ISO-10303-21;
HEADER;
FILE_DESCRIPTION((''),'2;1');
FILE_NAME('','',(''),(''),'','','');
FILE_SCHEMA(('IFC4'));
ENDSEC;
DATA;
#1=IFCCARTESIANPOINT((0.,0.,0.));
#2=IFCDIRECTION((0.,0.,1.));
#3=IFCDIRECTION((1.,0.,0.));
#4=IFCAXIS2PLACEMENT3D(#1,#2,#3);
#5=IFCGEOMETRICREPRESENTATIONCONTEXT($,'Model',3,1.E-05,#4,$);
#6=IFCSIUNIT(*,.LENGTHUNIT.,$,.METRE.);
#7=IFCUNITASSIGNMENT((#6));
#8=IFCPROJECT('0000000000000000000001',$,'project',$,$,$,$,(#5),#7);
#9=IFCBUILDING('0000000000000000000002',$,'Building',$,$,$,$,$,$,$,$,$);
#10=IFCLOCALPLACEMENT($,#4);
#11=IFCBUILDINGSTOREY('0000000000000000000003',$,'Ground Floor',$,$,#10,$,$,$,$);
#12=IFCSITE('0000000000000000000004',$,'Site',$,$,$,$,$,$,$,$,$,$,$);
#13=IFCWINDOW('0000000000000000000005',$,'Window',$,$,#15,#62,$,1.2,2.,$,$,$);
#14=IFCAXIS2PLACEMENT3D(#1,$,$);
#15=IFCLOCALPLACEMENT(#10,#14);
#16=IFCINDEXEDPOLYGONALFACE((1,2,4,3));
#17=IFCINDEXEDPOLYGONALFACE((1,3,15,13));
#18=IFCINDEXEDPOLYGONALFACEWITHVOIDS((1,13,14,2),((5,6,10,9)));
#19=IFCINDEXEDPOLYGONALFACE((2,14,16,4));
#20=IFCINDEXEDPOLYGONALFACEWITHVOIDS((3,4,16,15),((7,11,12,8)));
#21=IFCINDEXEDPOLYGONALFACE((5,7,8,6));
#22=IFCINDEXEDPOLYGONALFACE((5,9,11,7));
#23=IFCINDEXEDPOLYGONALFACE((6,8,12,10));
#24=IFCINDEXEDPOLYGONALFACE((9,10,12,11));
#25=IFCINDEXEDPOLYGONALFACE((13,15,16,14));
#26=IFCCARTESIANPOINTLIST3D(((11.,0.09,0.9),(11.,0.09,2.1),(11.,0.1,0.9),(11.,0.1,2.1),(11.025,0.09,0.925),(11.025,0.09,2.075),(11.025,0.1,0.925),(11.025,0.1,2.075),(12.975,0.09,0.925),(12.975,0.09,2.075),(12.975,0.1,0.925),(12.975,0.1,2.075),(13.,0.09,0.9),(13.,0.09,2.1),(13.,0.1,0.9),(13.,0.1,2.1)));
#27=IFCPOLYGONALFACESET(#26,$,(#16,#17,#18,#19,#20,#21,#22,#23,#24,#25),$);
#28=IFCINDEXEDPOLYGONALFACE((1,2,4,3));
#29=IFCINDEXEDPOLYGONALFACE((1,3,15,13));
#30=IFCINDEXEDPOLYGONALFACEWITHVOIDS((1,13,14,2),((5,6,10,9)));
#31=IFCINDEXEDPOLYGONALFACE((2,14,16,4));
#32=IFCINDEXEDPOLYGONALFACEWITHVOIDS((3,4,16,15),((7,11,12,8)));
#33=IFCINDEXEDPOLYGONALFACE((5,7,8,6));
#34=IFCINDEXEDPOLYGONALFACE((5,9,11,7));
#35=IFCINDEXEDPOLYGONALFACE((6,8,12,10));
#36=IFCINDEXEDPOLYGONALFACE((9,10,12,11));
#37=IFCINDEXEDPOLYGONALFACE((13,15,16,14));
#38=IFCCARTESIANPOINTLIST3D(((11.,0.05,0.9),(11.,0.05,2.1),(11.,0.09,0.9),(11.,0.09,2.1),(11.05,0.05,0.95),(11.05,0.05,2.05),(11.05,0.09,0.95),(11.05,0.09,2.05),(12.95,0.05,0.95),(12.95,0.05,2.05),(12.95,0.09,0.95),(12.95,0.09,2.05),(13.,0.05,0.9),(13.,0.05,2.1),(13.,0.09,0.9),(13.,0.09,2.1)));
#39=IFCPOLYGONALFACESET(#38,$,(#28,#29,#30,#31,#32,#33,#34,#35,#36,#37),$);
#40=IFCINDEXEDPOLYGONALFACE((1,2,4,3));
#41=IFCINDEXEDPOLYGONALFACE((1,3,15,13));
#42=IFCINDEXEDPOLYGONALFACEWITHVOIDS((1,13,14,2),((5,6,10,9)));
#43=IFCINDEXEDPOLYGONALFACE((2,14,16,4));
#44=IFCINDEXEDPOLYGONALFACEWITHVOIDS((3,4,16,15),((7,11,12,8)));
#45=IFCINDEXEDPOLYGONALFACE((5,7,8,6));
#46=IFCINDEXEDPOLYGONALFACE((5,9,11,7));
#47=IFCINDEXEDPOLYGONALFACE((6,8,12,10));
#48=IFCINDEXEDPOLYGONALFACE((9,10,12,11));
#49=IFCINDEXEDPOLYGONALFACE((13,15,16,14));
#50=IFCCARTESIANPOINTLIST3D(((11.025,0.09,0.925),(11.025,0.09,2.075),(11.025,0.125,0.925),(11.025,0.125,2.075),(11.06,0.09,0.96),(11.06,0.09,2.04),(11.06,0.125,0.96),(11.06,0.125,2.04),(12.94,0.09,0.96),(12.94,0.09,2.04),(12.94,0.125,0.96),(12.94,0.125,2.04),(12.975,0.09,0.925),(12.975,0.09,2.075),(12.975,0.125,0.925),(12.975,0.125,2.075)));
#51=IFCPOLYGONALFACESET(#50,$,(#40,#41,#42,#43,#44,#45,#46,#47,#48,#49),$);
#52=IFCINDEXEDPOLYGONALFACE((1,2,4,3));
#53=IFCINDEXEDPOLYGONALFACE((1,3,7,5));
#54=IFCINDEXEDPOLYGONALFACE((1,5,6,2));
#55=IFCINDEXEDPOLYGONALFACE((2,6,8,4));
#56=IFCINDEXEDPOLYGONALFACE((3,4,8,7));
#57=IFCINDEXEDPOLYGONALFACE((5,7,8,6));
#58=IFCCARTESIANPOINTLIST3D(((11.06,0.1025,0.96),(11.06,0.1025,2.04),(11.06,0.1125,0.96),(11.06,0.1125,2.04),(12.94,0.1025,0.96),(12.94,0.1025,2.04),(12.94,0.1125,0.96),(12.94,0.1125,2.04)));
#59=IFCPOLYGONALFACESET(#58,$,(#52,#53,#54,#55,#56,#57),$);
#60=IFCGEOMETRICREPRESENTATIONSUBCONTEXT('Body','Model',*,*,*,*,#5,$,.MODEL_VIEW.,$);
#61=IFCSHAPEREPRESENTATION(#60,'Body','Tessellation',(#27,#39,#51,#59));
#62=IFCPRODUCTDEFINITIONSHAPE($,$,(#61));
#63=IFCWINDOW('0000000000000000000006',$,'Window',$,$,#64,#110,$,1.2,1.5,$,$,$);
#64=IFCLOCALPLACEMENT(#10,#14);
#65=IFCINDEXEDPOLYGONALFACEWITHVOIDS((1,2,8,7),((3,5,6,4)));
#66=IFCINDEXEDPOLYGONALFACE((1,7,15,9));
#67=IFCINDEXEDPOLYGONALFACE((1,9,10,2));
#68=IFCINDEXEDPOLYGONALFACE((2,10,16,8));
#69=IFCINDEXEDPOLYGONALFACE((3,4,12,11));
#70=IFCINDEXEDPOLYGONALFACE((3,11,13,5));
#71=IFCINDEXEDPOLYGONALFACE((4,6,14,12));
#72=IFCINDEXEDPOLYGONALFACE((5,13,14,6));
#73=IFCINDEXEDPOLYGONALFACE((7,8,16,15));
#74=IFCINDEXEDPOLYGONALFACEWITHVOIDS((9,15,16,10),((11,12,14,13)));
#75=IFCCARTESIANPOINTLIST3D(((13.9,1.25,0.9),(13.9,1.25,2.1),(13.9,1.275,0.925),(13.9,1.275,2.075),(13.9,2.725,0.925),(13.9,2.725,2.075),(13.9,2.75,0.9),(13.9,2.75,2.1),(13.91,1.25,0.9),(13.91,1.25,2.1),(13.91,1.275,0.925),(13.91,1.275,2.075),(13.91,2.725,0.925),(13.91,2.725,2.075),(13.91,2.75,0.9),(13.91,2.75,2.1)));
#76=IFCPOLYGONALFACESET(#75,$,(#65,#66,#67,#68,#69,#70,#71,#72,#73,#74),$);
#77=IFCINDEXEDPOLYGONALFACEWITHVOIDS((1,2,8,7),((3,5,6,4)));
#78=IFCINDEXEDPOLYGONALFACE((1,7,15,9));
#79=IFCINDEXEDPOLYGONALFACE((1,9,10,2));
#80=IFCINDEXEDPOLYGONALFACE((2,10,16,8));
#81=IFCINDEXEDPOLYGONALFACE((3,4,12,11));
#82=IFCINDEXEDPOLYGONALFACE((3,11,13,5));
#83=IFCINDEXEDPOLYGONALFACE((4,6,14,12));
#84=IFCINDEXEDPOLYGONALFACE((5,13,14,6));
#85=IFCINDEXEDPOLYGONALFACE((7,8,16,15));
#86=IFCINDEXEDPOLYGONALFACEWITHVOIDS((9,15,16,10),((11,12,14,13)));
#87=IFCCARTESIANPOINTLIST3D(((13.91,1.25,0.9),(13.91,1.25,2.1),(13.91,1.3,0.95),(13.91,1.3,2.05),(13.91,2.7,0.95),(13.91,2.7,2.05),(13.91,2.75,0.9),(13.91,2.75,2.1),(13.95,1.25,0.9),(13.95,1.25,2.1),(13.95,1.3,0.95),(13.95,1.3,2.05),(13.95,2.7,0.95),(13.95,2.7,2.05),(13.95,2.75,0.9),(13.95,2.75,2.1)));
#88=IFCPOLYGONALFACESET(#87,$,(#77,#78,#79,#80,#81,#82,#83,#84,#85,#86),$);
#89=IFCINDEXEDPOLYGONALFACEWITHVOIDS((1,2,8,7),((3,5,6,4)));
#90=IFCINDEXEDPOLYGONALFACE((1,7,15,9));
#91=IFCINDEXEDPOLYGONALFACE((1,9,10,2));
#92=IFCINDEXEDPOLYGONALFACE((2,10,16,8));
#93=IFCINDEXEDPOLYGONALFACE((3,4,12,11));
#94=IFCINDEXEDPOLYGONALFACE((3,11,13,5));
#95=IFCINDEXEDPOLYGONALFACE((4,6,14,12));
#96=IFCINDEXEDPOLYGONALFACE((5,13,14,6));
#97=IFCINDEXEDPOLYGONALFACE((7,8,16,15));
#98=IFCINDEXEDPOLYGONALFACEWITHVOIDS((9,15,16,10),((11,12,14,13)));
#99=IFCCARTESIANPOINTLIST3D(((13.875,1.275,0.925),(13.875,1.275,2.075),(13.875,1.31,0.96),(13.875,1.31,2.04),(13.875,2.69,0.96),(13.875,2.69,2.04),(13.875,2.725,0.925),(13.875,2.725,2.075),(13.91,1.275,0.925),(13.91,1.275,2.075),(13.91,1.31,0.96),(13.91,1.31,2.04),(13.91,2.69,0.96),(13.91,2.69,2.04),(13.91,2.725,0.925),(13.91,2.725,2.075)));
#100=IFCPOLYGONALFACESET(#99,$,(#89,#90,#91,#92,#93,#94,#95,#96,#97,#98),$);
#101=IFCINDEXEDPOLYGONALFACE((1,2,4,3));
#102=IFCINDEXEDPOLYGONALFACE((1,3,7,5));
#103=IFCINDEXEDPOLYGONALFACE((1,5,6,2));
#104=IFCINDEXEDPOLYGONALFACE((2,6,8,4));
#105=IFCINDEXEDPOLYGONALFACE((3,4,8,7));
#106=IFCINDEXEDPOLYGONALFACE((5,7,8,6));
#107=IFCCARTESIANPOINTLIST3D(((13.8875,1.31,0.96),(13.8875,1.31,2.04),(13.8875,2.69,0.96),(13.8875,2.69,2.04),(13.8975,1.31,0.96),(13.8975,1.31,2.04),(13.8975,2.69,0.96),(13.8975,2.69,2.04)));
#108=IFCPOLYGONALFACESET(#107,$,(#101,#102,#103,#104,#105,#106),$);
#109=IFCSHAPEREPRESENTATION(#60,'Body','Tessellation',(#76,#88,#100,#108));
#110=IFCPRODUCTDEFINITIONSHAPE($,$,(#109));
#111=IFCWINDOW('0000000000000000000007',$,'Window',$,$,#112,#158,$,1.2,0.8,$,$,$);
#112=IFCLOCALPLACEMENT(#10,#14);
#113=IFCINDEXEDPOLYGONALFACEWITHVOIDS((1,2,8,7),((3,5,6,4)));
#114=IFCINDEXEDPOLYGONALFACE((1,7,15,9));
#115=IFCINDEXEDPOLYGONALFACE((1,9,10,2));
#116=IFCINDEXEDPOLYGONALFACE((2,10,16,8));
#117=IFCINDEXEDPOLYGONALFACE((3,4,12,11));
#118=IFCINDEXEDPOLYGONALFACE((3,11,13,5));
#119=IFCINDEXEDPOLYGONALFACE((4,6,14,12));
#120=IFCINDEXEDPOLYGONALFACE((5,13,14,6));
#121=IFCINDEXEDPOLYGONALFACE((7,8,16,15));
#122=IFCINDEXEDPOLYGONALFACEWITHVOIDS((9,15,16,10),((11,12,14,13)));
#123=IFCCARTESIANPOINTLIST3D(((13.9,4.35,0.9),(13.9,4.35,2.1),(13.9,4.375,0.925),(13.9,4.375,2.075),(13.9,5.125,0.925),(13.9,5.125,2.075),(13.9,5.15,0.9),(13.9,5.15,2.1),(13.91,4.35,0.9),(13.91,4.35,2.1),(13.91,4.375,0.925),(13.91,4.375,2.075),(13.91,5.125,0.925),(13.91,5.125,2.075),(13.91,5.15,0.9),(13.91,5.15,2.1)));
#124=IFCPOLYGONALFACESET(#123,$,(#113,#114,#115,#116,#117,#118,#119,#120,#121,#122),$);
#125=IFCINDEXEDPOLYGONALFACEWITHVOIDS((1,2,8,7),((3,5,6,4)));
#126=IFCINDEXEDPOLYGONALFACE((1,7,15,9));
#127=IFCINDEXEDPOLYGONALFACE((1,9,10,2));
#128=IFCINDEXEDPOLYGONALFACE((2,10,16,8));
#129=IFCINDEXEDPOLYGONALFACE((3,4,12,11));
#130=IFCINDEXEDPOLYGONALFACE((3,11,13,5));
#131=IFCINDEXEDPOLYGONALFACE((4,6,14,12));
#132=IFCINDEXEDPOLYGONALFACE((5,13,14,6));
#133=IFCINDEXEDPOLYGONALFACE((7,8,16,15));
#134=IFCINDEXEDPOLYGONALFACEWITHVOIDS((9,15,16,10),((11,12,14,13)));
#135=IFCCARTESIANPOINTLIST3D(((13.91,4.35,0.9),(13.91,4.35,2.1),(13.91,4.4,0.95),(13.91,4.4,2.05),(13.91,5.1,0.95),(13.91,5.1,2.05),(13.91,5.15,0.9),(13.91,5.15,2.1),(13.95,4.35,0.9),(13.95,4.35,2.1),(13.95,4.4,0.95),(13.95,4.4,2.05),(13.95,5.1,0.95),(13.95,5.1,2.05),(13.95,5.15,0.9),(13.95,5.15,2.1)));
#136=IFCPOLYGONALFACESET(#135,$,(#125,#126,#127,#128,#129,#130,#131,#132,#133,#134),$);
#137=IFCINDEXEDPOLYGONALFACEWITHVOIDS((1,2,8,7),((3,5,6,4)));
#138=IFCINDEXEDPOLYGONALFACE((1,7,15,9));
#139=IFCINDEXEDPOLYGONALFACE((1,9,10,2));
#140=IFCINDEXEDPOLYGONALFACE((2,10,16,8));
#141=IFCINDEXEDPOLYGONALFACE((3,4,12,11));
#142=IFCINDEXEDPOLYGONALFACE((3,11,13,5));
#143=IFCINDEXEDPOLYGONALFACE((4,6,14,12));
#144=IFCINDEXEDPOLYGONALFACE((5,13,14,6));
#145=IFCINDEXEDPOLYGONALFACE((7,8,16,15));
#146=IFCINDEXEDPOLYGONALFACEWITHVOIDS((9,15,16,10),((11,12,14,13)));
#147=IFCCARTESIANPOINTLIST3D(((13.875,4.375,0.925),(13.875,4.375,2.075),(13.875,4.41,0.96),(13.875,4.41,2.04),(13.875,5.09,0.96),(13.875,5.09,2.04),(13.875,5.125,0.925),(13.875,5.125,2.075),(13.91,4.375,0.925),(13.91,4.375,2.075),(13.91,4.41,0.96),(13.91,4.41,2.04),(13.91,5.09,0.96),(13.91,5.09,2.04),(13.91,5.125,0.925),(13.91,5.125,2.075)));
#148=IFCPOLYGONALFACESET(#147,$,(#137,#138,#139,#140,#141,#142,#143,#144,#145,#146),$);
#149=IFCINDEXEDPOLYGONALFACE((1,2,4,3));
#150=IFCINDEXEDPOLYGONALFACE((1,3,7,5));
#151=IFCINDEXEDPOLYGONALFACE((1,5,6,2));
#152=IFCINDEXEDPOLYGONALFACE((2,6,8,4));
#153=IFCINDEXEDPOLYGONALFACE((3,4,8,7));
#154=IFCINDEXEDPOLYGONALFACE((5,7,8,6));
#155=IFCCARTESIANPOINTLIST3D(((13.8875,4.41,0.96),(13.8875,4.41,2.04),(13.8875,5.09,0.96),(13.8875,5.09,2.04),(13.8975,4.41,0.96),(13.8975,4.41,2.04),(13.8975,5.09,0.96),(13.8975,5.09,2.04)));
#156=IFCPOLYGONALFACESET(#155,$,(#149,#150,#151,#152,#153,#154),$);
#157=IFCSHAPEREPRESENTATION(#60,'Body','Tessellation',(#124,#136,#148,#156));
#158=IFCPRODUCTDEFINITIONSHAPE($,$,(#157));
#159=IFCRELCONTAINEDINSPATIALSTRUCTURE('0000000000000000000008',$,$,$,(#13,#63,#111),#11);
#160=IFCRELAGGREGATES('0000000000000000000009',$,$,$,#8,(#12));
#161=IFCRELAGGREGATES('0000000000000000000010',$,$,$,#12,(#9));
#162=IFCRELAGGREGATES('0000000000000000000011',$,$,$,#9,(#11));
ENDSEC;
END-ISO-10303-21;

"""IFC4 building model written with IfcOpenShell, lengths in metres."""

from ifc_helpers import new_model, si_unit, frame, origin_with_axes, place, context, subcontext, project, spatial, line, indexed_curve, outline, extrude, element, save


model = new_model("IFC4")

# Units and contexts
model_context = context("Model", 3, precision=1e-05, world=origin_with_axes())
body_context = subcontext(model_context, "Body", "Model", "MODEL_VIEW")
ifc_project = project(units=[si_unit("LENGTHUNIT", "METRE")], contexts=[model_context])

# Site, building, storey
site = spatial("IfcSite", under=ifc_project, Name="Site")
building = spatial("IfcBuilding", under=site, Name="Building")
storey_placement = place(None, origin_with_axes())
storey = spatial("IfcBuildingStorey", under=building, at=storey_placement, Name="Ground Floor")

# Windows
window_1_placement = place(storey_placement, frame((11.0, 0.0, 0.9), z_axis=(0.0, 0.0, 1.0), x_axis=(1.0, 0.0, 0.0)))
element("IfcWindow", 1, at=window_1_placement, inside=storey, Name="Window", OverallHeight=1.2, OverallWidth=2.0, context=body_context, shape_type="SweptSolid", body=[
    extrude(outline(indexed_curve([(0.0, 0.0), (2.0, 0.0), (2.0, 1.2), (0.0, 1.2)], segments=[line(1, 2, 3, 4, 1)]), holes=[indexed_curve([(0.025, 0.025), (1.975, 0.025), (1.975, 1.175), (0.025, 1.175)], segments=[line(1, 2, 3, 4, 1)])]), frame((0.0, 0.09, 0.0), z_axis=(0.0, -1.0, 0.0), x_axis=(1.0, 0.0, 0.0)), (0.0, 0.0, -1.0), 0.01),
    extrude(outline(indexed_curve([(0.0, 0.0), (2.0, 0.0), (2.0, 1.2), (0.0, 1.2)], segments=[line(1, 2, 3, 4, 1)]), holes=[indexed_curve([(0.05, 0.05), (1.95, 0.05), (1.95, 1.15), (0.05, 1.15)], segments=[line(1, 2, 3, 4, 1)])]), frame((0.0, 0.05, 0.0), z_axis=(0.0, -1.0, 0.0), x_axis=(1.0, 0.0, 0.0)), (0.0, 0.0, -1.0), 0.04),
    extrude(outline(indexed_curve([(0.0, 0.0), (1.95, 0.0), (1.95, 1.15), (0.0, 1.15)], segments=[line(1, 2, 3, 4, 1)]), holes=[indexed_curve([(0.035, 0.035), (1.915, 0.035), (1.915, 1.115), (0.035, 1.115)], segments=[line(1, 2, 3, 4, 1)])]), frame((0.025, 0.09, 0.025), z_axis=(0.0, -1.0, 0.0), x_axis=(1.0, 0.0, 0.0)), (0.0, 0.0, -1.0), 0.035),
    extrude(outline(indexed_curve([(0.035, 0.035), (1.915, 0.035), (1.915, 1.115), (0.035, 1.115)], segments=[line(1, 2, 3, 4, 1)])), frame((0.025, 0.1025, 0.025), z_axis=(0.0, -1.0, 0.0), x_axis=(1.0, 0.0, 0.0)), (0.0, 0.0, -1.0), 0.01),
])
window_2_placement = place(storey_placement, frame((14.0, 1.25, 0.9), z_axis=(0.0, 0.0, 1.0), x_axis=(0.0, 1.0, 0.0)))
element("IfcWindow", 2, at=window_2_placement, inside=storey, Name="Window", OverallHeight=1.2, OverallWidth=1.5, context=body_context, shape_type="SweptSolid", body=[
    extrude(outline(indexed_curve([(0.0, 0.0), (1.5, 0.0), (1.5, 1.2), (0.0, 1.2)], segments=[line(1, 2, 3, 4, 1)]), holes=[indexed_curve([(0.025, 0.025), (1.475, 0.025), (1.475, 1.175), (0.025, 1.175)], segments=[line(1, 2, 3, 4, 1)])]), frame((0.0, 0.09, 0.0), z_axis=(0.0, -1.0, 0.0), x_axis=(1.0, 0.0, 0.0)), (0.0, 0.0, -1.0), 0.01),
    extrude(outline(indexed_curve([(0.0, 0.0), (1.5, 0.0), (1.5, 1.2), (0.0, 1.2)], segments=[line(1, 2, 3, 4, 1)]), holes=[indexed_curve([(0.05, 0.05), (1.45, 0.05), (1.45, 1.15), (0.05, 1.15)], segments=[line(1, 2, 3, 4, 1)])]), frame((0.0, 0.05, 0.0), z_axis=(0.0, -1.0, 0.0), x_axis=(1.0, 0.0, 0.0)), (0.0, 0.0, -1.0), 0.04),
    extrude(outline(indexed_curve([(0.0, 0.0), (1.45, 0.0), (1.45, 1.15), (0.0, 1.15)], segments=[line(1, 2, 3, 4, 1)]), holes=[indexed_curve([(0.035, 0.035), (1.415, 0.035), (1.415, 1.115), (0.035, 1.115)], segments=[line(1, 2, 3, 4, 1)])]), frame((0.025, 0.09, 0.025), z_axis=(0.0, -1.0, 0.0), x_axis=(1.0, 0.0, 0.0)), (0.0, 0.0, -1.0), 0.035),
    extrude(outline(indexed_curve([(0.035, 0.035), (1.415, 0.035), (1.415, 1.115), (0.035, 1.115)], segments=[line(1, 2, 3, 4, 1)])), frame((0.025, 0.1025, 0.025), z_axis=(0.0, -1.0, 0.0), x_axis=(1.0, 0.0, 0.0)), (0.0, 0.0, -1.0), 0.01),
])
window_3_placement = place(storey_placement, frame((14.0, 4.35, 0.9), z_axis=(0.0, 0.0, 1.0), x_axis=(0.0, 1.0, 0.0)))
element("IfcWindow", 3, at=window_3_placement, inside=storey, Name="Window", OverallHeight=1.2, OverallWidth=0.8, context=body_context, shape_type="SweptSolid", body=[
    extrude(outline(indexed_curve([(0.0, 0.0), (0.8, 0.0), (0.8, 1.2), (0.0, 1.2)], segments=[line(1, 2, 3, 4, 1)]), holes=[indexed_curve([(0.025, 0.025), (0.775, 0.025), (0.775, 1.175), (0.025, 1.175)], segments=[line(1, 2, 3, 4, 1)])]), frame((0.0, 0.09, 0.0), z_axis=(0.0, -1.0, 0.0), x_axis=(1.0, 0.0, 0.0)), (0.0, 0.0, -1.0), 0.01),
    extrude(outline(indexed_curve([(0.0, 0.0), (0.8, 0.0), (0.8, 1.2), (0.0, 1.2)], segments=[line(1, 2, 3, 4, 1)]), holes=[indexed_curve([(0.05, 0.05), (0.75, 0.05), (0.75, 1.15), (0.05, 1.15)], segments=[line(1, 2, 3, 4, 1)])]), frame((0.0, 0.05, 0.0), z_axis=(0.0, -1.0, 0.0), x_axis=(1.0, 0.0, 0.0)), (0.0, 0.0, -1.0), 0.04),
    extrude(outline(indexed_curve([(0.0, 0.0), (0.75, 0.0), (0.75, 1.15), (0.0, 1.15)], segments=[line(1, 2, 3, 4, 1)]), holes=[indexed_curve([(0.035, 0.035), (0.715, 0.035), (0.715, 1.115), (0.035, 1.115)], segments=[line(1, 2, 3, 4, 1)])]), frame((0.025, 0.09, 0.025), z_axis=(0.0, -1.0, 0.0), x_axis=(1.0, 0.0, 0.0)), (0.0, 0.0, -1.0), 0.035),
    extrude(outline(indexed_curve([(0.035, 0.035), (0.715, 0.035), (0.715, 1.115), (0.035, 1.115)], segments=[line(1, 2, 3, 4, 1)])), frame((0.025, 0.1025, 0.025), z_axis=(0.0, -1.0, 0.0), x_axis=(1.0, 0.0, 0.0)), (0.0, 0.0, -1.0), 0.01),
])

save(model, "model.ifc")
